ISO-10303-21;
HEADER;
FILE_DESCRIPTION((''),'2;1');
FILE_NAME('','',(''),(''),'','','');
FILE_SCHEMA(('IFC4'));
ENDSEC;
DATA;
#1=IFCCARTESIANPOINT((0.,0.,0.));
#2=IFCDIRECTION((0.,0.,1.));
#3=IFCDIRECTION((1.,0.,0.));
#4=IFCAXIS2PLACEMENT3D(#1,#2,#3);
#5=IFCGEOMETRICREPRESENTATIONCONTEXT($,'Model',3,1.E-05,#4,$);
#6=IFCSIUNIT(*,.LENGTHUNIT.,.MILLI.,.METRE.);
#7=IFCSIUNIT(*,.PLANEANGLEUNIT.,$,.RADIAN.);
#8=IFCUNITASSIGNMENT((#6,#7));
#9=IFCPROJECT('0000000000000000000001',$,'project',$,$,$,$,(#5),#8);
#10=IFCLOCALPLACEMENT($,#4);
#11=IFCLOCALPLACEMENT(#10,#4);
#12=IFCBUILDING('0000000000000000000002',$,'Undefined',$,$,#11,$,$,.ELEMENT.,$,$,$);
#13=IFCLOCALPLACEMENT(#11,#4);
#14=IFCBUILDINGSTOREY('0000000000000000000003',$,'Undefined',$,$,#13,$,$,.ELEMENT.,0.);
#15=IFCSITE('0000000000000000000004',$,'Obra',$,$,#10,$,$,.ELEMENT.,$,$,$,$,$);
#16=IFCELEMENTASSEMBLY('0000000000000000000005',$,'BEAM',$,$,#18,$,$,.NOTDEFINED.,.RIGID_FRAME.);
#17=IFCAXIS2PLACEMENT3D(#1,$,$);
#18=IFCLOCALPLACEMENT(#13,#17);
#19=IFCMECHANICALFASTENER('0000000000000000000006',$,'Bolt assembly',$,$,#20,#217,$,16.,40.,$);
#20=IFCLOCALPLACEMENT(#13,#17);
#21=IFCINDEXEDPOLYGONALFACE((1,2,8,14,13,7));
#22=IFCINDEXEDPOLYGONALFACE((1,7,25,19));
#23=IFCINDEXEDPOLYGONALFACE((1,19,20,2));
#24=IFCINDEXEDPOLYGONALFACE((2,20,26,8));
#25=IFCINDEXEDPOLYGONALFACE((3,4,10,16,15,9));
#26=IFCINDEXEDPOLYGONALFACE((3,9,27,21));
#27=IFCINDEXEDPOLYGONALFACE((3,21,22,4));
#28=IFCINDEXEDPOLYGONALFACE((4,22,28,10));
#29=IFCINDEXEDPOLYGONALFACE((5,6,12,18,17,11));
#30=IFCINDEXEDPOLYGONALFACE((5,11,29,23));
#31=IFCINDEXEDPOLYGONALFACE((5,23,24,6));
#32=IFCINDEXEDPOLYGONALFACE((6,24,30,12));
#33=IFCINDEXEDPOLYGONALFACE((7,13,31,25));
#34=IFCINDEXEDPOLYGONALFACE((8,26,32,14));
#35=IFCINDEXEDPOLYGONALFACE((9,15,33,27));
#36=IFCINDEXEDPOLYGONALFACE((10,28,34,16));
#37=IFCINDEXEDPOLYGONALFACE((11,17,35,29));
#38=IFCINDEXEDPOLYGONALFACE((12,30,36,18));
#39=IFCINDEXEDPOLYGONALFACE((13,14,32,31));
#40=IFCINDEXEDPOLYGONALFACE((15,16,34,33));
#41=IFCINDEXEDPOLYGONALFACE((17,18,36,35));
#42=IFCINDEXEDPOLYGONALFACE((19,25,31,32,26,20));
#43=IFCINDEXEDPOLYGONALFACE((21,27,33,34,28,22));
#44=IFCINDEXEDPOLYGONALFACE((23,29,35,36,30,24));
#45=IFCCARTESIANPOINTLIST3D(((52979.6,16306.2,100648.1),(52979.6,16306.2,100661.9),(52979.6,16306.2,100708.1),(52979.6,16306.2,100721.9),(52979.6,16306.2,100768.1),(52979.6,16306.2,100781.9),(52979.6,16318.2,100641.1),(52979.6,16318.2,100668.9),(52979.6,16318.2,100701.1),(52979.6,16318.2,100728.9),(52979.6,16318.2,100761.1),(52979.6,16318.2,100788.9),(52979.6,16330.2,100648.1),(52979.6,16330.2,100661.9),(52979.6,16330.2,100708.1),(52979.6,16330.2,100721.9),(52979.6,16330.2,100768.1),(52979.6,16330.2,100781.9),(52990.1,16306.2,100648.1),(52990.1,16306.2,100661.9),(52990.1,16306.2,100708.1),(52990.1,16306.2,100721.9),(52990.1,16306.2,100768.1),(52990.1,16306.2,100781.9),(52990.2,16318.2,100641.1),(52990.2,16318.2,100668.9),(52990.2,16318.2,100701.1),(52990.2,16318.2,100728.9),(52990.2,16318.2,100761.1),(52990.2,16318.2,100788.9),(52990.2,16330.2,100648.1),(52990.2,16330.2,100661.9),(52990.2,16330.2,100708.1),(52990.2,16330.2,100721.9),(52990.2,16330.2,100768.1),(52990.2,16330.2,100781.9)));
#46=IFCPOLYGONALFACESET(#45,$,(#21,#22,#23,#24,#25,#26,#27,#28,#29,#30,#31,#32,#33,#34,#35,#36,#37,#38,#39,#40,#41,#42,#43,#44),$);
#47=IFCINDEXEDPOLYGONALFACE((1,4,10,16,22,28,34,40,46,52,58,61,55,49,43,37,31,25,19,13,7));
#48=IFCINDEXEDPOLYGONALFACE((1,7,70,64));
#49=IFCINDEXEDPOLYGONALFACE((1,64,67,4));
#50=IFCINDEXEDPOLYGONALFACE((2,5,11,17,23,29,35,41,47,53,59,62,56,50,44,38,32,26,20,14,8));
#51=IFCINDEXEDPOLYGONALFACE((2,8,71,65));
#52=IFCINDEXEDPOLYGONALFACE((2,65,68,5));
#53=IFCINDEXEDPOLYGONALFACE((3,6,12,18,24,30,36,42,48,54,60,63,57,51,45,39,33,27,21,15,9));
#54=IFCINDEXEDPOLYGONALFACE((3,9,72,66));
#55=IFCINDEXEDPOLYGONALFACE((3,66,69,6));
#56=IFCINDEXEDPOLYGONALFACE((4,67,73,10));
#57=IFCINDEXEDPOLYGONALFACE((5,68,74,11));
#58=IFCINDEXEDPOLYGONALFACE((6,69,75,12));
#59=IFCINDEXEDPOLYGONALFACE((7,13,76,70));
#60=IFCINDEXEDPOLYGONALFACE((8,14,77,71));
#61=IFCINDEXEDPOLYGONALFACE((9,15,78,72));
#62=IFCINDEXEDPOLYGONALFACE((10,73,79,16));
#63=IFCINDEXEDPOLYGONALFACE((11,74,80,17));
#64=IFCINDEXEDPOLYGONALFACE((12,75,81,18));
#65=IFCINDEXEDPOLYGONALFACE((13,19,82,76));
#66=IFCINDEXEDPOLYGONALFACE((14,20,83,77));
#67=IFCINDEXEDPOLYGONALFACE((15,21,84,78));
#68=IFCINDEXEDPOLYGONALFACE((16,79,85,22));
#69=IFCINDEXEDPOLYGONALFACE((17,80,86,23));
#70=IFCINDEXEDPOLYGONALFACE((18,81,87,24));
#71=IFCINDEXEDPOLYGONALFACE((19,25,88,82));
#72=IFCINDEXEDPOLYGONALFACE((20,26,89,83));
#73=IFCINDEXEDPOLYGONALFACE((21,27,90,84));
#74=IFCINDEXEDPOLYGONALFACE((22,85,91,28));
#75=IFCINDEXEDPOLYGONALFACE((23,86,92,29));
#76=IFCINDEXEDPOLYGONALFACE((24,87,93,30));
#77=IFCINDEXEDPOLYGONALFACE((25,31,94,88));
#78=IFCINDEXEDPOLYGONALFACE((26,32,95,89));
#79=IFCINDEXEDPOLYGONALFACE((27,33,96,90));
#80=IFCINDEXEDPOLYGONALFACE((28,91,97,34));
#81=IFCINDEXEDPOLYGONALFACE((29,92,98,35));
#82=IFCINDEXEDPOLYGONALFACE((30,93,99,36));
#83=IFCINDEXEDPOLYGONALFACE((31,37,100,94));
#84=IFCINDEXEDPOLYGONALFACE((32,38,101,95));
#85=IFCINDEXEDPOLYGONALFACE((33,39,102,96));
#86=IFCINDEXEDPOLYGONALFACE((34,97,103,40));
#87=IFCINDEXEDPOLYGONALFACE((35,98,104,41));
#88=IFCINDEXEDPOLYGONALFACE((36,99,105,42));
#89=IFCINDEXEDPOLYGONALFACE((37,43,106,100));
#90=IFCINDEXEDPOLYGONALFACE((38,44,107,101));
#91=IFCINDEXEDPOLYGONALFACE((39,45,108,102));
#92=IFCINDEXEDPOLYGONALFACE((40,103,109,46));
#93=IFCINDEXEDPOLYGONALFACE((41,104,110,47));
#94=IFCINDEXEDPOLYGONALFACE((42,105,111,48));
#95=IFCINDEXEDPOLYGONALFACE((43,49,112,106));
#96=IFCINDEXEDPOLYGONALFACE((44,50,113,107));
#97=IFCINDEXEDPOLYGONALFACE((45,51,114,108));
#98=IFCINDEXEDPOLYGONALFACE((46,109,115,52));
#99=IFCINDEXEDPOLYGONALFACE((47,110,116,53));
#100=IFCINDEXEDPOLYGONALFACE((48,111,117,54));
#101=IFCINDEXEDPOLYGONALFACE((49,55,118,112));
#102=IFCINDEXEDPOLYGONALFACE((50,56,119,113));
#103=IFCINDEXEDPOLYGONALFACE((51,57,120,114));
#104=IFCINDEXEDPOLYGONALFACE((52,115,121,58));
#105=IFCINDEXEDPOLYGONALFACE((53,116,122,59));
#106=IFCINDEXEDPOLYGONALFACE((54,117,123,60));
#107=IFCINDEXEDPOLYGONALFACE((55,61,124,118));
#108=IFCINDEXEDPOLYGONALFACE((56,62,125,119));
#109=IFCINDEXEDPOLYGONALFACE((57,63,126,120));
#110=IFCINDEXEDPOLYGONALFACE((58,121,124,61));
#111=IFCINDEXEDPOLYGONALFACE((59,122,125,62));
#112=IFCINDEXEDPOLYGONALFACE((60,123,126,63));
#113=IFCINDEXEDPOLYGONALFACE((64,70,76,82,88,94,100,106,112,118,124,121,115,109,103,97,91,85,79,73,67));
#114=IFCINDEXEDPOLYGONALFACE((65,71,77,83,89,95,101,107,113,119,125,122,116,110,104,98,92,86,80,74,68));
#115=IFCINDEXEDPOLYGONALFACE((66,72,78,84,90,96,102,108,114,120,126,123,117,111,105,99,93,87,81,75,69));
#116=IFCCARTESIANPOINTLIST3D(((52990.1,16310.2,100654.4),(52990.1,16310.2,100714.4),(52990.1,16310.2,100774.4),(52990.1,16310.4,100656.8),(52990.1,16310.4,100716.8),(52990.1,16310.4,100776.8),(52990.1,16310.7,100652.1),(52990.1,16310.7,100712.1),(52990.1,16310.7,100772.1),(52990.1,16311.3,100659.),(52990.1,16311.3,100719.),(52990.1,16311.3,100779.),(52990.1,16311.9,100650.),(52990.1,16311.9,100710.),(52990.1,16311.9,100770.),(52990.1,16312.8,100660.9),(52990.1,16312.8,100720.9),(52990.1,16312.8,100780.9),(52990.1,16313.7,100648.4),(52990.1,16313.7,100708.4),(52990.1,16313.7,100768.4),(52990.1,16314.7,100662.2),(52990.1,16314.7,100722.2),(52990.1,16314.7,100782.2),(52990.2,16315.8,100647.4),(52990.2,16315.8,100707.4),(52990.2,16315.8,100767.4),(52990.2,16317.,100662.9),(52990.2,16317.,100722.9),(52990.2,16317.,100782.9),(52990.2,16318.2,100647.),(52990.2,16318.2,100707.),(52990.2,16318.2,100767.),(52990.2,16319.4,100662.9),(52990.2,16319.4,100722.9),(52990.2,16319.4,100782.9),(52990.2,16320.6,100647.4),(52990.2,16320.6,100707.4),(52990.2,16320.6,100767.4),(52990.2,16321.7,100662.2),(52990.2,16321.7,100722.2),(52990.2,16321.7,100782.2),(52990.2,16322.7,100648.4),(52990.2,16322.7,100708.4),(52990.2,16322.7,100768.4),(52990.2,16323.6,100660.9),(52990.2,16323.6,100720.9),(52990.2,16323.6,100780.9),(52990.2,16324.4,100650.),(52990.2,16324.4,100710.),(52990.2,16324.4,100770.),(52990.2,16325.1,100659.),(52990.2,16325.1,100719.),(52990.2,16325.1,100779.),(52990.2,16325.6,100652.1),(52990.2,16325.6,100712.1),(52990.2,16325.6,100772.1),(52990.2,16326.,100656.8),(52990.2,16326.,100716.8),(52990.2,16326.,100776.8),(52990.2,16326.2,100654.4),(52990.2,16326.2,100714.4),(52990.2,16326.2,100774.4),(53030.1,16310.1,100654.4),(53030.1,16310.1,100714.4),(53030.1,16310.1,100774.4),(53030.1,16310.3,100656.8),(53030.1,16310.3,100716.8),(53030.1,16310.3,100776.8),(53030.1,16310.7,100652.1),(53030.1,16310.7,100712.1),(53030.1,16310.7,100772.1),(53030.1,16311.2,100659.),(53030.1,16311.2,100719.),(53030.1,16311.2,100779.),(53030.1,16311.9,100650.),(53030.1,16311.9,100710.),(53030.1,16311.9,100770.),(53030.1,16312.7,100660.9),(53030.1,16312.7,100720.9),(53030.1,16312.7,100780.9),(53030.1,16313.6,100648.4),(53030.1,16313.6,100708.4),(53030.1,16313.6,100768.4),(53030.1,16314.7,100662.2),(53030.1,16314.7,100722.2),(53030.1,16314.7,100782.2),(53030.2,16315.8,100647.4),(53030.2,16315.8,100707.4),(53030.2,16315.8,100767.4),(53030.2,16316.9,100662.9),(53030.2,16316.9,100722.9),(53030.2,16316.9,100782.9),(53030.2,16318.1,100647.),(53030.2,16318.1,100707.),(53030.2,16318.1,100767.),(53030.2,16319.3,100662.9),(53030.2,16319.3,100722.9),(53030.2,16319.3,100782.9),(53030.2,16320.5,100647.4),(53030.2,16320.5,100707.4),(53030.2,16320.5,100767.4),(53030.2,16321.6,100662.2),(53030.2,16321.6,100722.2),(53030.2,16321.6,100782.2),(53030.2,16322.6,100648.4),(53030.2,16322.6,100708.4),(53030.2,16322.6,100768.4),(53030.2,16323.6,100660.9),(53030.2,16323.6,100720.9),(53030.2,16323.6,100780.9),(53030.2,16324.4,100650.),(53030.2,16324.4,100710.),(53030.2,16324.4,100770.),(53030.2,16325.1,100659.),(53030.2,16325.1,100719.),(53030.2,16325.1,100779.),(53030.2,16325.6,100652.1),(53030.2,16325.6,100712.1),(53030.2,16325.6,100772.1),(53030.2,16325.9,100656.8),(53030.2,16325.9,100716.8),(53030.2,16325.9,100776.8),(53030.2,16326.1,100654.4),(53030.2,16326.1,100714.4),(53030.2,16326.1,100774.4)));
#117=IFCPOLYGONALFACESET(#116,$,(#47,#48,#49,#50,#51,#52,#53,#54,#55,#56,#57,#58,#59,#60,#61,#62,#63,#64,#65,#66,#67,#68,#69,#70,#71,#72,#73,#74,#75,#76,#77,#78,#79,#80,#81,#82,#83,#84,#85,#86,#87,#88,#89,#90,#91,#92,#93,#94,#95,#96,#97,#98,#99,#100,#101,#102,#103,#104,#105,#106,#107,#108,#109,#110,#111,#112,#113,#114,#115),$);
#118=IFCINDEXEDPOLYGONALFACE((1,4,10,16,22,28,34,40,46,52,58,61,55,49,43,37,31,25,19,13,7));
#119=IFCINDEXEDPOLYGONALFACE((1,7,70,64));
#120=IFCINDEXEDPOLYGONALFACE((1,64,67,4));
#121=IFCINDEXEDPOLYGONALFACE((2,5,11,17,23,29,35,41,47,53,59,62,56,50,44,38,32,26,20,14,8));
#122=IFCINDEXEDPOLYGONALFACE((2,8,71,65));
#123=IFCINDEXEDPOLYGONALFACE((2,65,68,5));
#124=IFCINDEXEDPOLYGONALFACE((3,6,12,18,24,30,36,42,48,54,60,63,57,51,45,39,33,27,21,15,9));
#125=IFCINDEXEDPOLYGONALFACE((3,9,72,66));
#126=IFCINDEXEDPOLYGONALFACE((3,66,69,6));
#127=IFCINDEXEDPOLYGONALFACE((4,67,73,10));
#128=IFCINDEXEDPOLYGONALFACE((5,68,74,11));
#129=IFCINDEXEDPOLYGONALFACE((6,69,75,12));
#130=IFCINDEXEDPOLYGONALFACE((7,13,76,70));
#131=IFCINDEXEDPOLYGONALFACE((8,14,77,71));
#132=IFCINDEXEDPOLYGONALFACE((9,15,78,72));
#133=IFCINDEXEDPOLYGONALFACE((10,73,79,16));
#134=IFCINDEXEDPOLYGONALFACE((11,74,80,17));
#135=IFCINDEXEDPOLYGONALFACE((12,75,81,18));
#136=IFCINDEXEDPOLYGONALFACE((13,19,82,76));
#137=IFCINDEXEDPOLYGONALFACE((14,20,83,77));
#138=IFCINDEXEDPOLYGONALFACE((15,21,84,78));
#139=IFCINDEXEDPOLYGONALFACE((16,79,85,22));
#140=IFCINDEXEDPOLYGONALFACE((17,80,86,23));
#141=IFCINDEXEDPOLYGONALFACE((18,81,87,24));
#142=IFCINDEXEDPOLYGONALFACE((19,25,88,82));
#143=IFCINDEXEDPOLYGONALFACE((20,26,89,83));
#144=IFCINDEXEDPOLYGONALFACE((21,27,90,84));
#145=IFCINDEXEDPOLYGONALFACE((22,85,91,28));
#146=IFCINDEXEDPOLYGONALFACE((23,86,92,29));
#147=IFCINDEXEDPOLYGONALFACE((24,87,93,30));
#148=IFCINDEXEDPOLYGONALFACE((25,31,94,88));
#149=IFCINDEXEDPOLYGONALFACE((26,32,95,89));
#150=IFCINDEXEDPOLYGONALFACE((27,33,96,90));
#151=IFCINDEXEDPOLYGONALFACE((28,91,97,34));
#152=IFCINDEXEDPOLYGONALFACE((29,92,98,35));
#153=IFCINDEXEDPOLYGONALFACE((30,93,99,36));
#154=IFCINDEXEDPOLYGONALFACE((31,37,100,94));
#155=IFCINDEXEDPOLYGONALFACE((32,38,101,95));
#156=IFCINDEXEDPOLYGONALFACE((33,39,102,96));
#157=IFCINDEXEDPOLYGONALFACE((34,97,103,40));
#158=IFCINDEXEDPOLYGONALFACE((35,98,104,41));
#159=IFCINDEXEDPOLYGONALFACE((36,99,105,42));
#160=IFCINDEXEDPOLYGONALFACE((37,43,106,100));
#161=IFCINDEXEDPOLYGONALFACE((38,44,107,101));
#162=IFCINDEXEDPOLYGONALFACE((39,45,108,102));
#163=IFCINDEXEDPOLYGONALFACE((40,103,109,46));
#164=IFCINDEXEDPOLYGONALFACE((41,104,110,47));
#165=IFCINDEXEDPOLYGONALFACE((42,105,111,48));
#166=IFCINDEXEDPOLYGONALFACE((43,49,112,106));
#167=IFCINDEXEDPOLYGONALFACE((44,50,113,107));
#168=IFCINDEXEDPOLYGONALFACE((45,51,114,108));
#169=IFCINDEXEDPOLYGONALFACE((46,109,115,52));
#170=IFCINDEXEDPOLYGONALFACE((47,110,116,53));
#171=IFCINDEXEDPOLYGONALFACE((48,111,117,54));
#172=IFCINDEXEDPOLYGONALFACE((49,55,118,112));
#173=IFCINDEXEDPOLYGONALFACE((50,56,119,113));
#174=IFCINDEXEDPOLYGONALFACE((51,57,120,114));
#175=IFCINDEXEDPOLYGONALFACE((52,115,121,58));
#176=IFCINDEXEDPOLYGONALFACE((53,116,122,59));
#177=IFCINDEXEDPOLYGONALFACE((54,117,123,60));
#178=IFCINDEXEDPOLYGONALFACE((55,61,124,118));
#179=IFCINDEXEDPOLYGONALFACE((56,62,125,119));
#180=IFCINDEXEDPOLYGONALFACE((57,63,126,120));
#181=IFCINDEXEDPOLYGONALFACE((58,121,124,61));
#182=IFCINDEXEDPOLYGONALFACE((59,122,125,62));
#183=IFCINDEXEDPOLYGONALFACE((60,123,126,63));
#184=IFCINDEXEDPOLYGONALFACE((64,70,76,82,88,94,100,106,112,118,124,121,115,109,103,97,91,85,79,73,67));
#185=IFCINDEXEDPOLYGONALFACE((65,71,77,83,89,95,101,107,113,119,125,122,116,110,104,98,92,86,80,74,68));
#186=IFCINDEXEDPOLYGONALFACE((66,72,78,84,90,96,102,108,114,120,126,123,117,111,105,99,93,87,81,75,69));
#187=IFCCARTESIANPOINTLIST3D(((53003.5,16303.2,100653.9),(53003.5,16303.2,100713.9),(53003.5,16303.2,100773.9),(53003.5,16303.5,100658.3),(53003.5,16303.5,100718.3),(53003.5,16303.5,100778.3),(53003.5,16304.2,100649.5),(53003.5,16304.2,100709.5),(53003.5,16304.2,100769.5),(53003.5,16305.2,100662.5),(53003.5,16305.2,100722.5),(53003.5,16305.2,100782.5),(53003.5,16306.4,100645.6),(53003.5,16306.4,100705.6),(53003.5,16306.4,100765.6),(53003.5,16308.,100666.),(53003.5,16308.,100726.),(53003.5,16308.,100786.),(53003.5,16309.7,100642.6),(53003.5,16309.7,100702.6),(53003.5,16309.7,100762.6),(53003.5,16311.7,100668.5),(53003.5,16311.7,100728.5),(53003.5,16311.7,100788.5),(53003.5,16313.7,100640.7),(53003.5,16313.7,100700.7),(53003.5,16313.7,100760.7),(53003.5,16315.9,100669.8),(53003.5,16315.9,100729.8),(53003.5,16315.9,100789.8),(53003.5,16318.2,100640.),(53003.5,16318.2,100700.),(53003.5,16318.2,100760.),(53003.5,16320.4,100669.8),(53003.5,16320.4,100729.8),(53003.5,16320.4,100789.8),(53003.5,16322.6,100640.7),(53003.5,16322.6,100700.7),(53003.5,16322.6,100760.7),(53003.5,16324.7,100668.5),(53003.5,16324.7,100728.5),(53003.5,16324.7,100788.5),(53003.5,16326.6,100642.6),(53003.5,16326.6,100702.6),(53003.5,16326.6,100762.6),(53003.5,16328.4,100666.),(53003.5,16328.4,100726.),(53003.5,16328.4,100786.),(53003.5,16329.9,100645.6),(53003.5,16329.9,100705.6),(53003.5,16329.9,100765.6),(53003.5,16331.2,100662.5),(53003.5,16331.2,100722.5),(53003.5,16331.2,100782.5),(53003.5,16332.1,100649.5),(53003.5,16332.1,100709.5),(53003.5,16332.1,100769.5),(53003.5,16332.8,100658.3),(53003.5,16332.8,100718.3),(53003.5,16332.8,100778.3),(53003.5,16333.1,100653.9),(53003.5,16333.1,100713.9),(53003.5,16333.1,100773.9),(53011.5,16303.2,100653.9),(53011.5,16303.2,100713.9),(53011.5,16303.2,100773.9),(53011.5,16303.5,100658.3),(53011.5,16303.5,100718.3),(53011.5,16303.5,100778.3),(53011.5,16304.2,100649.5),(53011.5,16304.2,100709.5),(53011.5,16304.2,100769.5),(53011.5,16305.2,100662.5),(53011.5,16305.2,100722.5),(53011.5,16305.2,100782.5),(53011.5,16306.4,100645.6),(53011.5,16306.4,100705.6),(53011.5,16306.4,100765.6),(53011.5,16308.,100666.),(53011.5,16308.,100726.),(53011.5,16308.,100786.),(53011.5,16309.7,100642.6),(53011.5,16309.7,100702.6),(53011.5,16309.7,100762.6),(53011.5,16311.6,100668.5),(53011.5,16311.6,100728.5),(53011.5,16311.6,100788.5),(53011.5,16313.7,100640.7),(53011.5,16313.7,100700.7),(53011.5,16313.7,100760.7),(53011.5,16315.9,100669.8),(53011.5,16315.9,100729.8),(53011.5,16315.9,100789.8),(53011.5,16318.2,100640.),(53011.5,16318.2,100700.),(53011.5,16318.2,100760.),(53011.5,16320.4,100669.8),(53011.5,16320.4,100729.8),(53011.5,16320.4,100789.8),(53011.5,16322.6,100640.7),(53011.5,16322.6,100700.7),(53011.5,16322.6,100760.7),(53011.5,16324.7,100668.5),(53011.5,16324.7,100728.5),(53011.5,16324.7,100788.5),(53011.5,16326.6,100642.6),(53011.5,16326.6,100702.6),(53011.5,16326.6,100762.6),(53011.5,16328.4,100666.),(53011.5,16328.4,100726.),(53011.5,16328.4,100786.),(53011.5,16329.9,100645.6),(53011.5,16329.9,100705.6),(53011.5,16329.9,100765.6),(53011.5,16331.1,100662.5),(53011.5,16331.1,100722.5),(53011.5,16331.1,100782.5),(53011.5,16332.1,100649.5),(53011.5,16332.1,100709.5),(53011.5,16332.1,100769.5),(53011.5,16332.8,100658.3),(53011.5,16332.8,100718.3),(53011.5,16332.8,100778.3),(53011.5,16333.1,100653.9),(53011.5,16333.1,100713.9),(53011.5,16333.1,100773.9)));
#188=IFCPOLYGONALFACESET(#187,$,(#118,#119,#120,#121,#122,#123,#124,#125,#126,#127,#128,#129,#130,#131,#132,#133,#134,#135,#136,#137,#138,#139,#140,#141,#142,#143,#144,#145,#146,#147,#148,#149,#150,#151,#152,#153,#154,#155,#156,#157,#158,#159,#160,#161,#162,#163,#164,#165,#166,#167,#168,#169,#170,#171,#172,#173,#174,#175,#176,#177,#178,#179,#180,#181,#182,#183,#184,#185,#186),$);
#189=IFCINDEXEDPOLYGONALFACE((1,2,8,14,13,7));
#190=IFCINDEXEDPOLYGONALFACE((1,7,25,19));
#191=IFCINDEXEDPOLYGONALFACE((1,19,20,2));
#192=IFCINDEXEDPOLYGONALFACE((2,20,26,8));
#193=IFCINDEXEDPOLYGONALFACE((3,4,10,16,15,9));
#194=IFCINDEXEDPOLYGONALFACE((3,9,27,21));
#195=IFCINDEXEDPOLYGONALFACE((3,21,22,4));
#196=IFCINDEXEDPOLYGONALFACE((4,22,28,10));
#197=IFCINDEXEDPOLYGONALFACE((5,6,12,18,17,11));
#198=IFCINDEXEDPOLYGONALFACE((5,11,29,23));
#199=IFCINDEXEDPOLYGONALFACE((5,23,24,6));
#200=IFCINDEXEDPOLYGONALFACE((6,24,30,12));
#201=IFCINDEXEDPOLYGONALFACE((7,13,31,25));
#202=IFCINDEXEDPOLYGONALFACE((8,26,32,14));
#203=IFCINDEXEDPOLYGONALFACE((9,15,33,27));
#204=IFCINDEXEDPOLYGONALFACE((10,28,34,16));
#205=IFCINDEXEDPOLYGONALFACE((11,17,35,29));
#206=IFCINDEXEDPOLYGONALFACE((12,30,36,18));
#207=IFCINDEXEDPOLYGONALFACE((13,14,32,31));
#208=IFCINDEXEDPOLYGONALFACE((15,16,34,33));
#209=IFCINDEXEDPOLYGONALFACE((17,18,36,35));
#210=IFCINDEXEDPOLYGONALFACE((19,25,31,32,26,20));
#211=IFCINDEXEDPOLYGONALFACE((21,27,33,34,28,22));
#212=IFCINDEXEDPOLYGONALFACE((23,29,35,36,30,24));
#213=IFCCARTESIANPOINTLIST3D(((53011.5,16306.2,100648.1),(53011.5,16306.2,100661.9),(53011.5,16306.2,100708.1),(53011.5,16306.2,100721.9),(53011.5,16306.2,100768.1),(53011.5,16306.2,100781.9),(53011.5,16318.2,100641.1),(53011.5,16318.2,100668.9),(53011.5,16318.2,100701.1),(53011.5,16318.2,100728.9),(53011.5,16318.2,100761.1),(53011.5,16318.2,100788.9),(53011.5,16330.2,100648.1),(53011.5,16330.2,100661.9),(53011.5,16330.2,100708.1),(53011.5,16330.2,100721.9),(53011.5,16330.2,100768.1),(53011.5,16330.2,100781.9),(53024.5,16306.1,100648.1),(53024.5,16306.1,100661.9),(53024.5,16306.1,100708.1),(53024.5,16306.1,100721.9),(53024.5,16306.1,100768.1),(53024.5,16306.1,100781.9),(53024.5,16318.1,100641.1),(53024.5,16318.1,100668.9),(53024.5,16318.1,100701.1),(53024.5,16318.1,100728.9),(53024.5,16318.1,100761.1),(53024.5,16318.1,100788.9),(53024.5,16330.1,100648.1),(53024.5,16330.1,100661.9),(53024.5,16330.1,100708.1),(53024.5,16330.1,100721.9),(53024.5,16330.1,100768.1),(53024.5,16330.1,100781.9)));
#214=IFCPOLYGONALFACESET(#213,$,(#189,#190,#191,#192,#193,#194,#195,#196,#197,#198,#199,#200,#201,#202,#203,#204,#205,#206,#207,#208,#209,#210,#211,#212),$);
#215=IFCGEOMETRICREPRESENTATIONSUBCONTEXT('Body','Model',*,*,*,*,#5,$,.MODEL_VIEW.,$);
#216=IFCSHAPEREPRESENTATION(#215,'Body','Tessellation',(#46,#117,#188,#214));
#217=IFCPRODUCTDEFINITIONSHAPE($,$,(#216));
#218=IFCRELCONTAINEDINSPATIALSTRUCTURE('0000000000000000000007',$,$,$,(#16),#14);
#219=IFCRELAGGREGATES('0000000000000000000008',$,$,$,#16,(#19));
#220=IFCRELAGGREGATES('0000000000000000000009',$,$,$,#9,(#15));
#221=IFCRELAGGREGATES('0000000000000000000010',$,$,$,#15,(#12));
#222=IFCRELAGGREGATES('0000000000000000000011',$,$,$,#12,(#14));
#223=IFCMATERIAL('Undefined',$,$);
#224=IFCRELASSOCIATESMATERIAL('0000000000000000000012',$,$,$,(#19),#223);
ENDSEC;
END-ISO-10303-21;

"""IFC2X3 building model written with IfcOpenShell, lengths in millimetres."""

from ifc_helpers import new_model, si_unit, frame, origin_with_axes, origin_2d_with_axis, place, context, subcontext, project, spatial, polyline, circle, outline, extrude, source, transform, mapped, material, element, aggregate, save


model = new_model("IFC2X3")

# Units and contexts
model_context = context("Model", 3, precision=1e-05, world=origin_with_axes())
body_context = subcontext(model_context, "Body", "Model", "MODEL_VIEW")
ifc_project = project(units=[si_unit("LENGTHUNIT", "METRE", prefix="MILLI"), si_unit("PLANEANGLEUNIT", "RADIAN")], contexts=[model_context])

# Site, building, storey
site_placement = place(None, origin_with_axes())
site = spatial("IfcSite", under=ifc_project, at=site_placement, Name="Obra", CompositionType="ELEMENT")
building_placement = place(site_placement, origin_with_axes())
building = spatial("IfcBuilding", under=site, at=building_placement, Name="Undefined", CompositionType="ELEMENT")
storey_placement = place(building_placement, origin_with_axes())
storey = spatial("IfcBuildingStorey", under=building, at=storey_placement, Name="Undefined", CompositionType="ELEMENT", Elevation=0.0)

# Element assembly, mechanical fastener
assembly_1_placement = place(storey_placement, origin_with_axes())
assembly_1 = element("IfcElementAssembly", 1, at=assembly_1_placement, inside=storey, Name="BEAM", AssemblyPlace="NOTDEFINED", PredefinedType="RIGID_FRAME")
ifc_material_1 = material(Name="Undefined")
shared_shape_1 = source(origin_with_axes(), body_context, "Body", "SweptSolid", [
    extrude(outline(polyline([(13.9, 0.0), (6.9, 12.0), (-6.9, 12.0), (-13.9, 0.0), (-6.9, -12.0), (6.9, -12.0), (13.9, 0.0)])), frame((0.0, -19.7, 0.0), z_axis=(0.0, 1.0, 0.0), x_axis=(1.0, 0.0, 0.0)), (0.0, 0.0, 1.0), 10.6),
    extrude(circle(Radius=8.0, at=origin_2d_with_axis()), frame((0.0, -9.1, 0.0), z_axis=(0.0, 1.0, 0.0), x_axis=(1.0, 0.0, 0.0)), (0.0, 0.0, 1.0), 40.0),
    extrude(circle(Radius=15.0, at=origin_2d_with_axis()), frame((0.0, 4.2, 0.0), z_axis=(0.0, 1.0, 0.0), x_axis=(1.0, 0.0, 0.0)), (0.0, 0.0, 1.0), 8.0),
    extrude(outline(polyline([(13.9, 0.0), (6.9, 12.0), (-6.9, 12.0), (-13.9, 0.0), (-6.9, -12.0), (6.9, -12.0), (13.9, 0.0)])), frame((0.0, 12.2, 0.0), z_axis=(0.0, 1.0, 0.0), x_axis=(1.0, 0.0, 0.0)), (0.0, 0.0, 1.0), 13.0),
])
mechanical_fastener_1_placement = place(assembly_1_placement, frame((52999.3, 16368.2, 100835.0), z_axis=(-0.001649, -0.999999, 0.0), x_axis=(0.0, 0.0, -1.0)))
mechanical_fastener_1 = element("IfcMechanicalFastener", 2, at=mechanical_fastener_1_placement, material=ifc_material_1, Name="Bolt assembly", NominalDiameter=16.0, NominalLength=40.0, context=body_context, shape_type="MappedRepresentation", body=[
    mapped(shared_shape_1, transform((60.0, 0.0, 50.0))),
    mapped(shared_shape_1, transform((120.0, 0.0, 50.0))),
    mapped(shared_shape_1, transform((180.0, 0.0, 50.0))),
])
aggregate(assembly_1, [mechanical_fastener_1])

save(model, "model.ifc")
